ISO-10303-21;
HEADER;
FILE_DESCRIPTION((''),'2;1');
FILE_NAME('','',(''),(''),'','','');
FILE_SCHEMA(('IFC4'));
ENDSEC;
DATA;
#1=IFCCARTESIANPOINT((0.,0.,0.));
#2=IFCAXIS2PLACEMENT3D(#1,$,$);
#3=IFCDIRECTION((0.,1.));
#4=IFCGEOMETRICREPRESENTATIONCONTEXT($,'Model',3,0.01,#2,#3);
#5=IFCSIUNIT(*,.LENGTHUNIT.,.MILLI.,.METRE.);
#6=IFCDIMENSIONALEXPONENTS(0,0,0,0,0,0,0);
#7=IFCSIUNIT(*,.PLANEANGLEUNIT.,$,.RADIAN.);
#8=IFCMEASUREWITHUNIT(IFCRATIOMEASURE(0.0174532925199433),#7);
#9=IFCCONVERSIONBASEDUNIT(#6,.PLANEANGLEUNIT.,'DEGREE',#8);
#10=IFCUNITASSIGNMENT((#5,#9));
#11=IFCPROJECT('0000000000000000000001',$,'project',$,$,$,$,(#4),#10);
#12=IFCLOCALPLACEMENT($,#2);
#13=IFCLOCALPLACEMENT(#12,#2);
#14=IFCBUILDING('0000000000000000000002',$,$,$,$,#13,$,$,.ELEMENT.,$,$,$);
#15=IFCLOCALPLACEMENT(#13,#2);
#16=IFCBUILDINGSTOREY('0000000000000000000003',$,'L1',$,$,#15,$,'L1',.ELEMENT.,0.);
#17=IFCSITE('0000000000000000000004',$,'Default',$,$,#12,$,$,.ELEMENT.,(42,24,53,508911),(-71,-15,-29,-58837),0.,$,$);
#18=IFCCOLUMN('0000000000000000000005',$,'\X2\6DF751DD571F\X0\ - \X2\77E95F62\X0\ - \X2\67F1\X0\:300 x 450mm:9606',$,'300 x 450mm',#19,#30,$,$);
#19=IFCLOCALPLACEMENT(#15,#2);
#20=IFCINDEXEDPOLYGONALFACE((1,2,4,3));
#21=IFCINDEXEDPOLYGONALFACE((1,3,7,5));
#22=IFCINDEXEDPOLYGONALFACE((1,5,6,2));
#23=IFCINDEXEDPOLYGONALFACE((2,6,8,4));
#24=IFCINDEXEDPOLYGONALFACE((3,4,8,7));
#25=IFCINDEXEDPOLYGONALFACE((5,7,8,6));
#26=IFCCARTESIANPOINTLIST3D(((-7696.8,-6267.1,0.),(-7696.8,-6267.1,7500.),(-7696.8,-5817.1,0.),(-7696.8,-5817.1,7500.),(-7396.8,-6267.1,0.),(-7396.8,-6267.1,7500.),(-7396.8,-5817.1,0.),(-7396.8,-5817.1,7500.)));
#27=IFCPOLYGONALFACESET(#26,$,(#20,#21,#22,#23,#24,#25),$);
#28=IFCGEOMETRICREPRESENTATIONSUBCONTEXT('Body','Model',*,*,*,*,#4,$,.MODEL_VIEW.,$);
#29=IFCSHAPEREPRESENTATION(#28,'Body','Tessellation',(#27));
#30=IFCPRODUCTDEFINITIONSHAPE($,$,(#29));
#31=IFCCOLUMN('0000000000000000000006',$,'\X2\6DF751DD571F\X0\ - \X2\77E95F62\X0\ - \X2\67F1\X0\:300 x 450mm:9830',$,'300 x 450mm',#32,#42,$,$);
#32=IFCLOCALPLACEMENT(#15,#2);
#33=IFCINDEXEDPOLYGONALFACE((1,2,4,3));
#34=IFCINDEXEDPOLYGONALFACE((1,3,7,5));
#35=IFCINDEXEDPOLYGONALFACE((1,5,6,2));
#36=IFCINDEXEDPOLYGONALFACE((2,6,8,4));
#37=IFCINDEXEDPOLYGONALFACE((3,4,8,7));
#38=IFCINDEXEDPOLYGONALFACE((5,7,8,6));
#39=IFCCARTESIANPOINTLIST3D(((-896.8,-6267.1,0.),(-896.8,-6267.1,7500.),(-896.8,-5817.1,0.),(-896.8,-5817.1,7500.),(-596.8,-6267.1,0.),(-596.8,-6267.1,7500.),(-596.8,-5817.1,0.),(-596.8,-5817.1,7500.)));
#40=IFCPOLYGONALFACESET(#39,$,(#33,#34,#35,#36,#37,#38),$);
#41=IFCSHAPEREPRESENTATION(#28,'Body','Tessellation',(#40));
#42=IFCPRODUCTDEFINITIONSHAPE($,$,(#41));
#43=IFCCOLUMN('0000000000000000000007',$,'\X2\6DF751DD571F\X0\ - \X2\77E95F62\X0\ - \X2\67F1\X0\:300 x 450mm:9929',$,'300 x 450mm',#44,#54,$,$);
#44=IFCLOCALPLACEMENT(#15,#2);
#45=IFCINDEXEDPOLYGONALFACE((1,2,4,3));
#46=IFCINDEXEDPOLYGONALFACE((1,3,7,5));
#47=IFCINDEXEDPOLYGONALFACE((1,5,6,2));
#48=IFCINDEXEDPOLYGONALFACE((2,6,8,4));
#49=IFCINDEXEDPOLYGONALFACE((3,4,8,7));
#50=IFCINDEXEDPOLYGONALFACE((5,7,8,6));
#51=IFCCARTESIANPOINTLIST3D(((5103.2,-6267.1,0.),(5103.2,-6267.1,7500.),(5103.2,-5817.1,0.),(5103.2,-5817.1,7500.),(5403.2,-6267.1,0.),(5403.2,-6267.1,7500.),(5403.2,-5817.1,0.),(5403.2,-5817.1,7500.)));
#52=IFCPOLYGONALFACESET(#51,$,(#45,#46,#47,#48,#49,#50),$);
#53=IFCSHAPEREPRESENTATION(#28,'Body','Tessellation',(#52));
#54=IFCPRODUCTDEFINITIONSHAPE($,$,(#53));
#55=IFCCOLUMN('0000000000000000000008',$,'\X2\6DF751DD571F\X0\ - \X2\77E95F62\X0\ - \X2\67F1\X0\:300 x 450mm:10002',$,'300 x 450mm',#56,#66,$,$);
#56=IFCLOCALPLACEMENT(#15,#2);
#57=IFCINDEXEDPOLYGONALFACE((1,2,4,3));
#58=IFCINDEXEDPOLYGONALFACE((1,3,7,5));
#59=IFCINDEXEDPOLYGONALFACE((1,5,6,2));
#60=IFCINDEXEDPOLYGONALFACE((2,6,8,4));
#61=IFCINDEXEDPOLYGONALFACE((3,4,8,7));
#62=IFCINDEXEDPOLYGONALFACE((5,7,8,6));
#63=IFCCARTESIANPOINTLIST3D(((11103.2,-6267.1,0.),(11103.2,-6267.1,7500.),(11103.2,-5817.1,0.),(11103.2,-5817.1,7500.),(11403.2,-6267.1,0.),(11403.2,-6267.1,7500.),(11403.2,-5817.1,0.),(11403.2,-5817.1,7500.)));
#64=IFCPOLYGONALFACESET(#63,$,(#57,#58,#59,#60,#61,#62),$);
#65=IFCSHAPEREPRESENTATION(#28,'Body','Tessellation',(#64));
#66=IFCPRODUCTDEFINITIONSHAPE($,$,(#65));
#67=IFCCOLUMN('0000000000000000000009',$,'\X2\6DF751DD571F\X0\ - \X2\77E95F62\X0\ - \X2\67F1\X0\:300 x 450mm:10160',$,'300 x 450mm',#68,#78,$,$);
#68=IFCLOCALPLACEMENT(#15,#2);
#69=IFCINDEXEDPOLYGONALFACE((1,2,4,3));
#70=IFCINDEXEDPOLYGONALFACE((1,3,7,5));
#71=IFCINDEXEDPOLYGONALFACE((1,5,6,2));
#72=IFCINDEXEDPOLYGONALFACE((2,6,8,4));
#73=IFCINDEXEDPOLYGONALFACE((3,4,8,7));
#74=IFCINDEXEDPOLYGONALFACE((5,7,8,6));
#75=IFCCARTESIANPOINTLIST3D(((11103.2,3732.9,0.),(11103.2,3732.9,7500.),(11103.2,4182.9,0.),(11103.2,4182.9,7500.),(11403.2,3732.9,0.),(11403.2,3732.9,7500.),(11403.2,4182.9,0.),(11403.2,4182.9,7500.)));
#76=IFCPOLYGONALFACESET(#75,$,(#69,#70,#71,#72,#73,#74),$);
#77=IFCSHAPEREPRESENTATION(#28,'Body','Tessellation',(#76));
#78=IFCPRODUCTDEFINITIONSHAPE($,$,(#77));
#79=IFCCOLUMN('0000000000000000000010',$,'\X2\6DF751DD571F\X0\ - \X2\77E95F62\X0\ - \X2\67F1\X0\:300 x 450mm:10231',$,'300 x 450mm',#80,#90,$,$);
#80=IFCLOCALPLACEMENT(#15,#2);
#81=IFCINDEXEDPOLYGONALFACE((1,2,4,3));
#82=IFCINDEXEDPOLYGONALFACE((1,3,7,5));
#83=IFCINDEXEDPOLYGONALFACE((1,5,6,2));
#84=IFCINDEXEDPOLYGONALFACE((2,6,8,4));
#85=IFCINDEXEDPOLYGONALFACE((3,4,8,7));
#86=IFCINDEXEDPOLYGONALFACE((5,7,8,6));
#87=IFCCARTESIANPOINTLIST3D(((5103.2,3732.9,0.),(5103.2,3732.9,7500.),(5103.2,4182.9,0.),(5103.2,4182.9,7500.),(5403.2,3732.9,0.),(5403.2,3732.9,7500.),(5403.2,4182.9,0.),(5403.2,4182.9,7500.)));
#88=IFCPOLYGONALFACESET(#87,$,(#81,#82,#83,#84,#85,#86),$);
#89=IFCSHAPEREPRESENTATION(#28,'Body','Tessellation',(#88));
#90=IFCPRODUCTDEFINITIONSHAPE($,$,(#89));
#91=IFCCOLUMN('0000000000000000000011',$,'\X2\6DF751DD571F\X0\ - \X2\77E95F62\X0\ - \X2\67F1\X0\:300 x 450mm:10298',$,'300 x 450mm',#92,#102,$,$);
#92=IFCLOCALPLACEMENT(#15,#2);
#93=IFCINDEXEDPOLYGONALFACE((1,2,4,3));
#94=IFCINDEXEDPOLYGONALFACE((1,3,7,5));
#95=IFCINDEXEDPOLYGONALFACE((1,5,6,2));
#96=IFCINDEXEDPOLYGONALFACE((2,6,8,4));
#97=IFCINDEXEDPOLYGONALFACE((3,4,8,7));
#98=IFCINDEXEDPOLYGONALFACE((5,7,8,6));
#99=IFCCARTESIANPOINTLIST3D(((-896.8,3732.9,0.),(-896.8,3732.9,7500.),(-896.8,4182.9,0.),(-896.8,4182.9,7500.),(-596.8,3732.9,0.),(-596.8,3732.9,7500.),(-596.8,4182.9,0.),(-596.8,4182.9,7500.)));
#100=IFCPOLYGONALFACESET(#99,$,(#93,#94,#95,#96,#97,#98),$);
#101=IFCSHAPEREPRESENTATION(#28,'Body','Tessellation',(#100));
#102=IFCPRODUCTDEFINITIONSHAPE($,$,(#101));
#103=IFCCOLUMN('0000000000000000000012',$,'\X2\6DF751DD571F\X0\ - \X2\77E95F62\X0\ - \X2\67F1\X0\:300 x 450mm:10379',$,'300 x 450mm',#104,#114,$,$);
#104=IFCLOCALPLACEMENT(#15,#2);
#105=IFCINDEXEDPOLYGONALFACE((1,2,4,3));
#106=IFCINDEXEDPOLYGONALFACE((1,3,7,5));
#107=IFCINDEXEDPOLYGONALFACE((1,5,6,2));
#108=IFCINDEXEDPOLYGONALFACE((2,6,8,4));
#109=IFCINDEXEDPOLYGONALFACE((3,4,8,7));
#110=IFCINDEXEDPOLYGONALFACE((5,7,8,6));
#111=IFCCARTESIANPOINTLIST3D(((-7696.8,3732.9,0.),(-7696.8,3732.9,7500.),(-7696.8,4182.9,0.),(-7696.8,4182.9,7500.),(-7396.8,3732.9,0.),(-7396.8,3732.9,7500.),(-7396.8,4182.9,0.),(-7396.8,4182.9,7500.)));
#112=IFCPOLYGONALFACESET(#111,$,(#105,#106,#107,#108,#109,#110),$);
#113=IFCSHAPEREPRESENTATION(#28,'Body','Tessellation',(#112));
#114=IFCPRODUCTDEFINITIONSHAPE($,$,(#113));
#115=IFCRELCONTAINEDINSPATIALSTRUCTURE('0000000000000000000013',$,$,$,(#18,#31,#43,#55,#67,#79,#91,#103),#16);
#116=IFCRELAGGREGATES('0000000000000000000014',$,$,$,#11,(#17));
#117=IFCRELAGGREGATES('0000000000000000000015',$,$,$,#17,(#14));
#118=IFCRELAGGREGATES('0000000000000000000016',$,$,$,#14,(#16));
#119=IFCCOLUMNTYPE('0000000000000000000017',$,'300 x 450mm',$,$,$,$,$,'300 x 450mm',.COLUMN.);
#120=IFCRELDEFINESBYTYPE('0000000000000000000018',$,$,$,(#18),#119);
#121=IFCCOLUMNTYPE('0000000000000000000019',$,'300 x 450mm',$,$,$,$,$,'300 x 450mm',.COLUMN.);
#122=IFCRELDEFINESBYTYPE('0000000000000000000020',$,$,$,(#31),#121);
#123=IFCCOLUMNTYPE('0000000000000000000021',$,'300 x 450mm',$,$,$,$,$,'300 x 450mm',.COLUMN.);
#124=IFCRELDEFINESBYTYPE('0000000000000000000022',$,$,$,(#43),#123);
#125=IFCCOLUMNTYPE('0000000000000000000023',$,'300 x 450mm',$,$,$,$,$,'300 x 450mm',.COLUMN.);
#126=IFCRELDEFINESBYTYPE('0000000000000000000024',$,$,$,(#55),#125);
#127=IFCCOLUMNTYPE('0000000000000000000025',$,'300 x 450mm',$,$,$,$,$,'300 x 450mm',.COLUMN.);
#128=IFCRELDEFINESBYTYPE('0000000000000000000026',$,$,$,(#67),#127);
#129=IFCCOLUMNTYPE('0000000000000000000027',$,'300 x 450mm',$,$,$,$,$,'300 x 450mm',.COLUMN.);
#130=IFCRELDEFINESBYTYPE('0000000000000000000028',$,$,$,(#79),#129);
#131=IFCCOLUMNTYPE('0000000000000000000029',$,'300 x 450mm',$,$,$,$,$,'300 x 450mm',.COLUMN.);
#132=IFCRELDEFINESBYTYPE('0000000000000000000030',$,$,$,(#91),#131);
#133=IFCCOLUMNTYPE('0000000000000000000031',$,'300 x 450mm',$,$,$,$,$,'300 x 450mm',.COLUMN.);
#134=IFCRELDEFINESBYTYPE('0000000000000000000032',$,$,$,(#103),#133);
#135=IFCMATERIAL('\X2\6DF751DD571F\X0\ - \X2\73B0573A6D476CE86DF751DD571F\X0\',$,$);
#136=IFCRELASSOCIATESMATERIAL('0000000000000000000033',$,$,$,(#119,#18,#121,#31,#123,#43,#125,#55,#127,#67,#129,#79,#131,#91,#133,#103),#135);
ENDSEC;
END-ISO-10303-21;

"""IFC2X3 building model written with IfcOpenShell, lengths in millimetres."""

from ifc_helpers import new_model, entity, si_unit, converted_unit, direction, frame, frame_2d, origin, origin_2d_with_axis, place, context, subcontext, project, spatial, rectangle, extrude, source, transform, mapped, material, type_object, type_shapes, element, save


model = new_model("IFC2X3")

# Units and contexts
model_context = context("Model", 3, precision=0.01, world=origin(), true_north=direction((0.0, 1.0)))
body_context = subcontext(model_context, "Body", "Model", "MODEL_VIEW")
ifc_project = project(units=[si_unit("LENGTHUNIT", "METRE", prefix="MILLI"), converted_unit("PLANEANGLEUNIT", "DEGREE", entity("IfcRatioMeasure", 0.0174532925199433), si_unit("PLANEANGLEUNIT", "RADIAN"), dimensions=[0, 0, 0, 0, 0, 0, 0])], contexts=[model_context])

# Site, building, storey
site_placement = place(None, origin())
site = spatial("IfcSite", under=ifc_project, at=site_placement, Name="Default", CompositionType="ELEMENT", RefLatitude=(42, 24, 53, 508911), RefLongitude=(-71, -15, -29, -58837), RefElevation=0.0)
building_placement = place(site_placement, origin())
building = spatial("IfcBuilding", under=site, at=building_placement, CompositionType="ELEMENT")
storey_placement = place(building_placement, origin())
storey = spatial("IfcBuildingStorey", under=building, at=storey_placement, Name="L1", LongName="L1", CompositionType="ELEMENT", Elevation=0.0)

# Columns
ifc_material = material(Name="混凝土 - 现场浇注混凝土")
column_type_1 = type_object("IfcColumnType", Name="300 x 450mm", ElementType="300 x 450mm", PredefinedType="COLUMN", material=ifc_material)
shared_shape_1 = source(origin(), body_context, "Body", "SweptSolid", [
    extrude(rectangle(XDim=450.0, YDim=300.0, at=frame_2d((0.0, 0.0), x_axis=(1.0, 0.0))), frame((-7546.8, -6042.1, 0.0), z_axis=(0.0, 0.0, 1.0), x_axis=(0.0, -1.0, 0.0)), (0.0, 0.0, 1.0), 7500.0),
])
type_shapes(column_type_1, [shared_shape_1])
column_1_placement = place(storey_placement, origin())
element("IfcColumn", 1, at=column_1_placement, inside=storey, type_object=column_type_1, material=ifc_material, Name="混凝土 - 矩形 - 柱:300 x 450mm:9606", ObjectType="300 x 450mm", context=body_context, shape_type="MappedRepresentation", body=[
    mapped(shared_shape_1, transform((0.0, 0.0, 0.0), scale=1.0)),
])
column_type_2 = type_object("IfcColumnType", Name="300 x 450mm", ElementType="300 x 450mm", PredefinedType="COLUMN", material=ifc_material)
shared_shape_2 = source(origin(), body_context, "Body", "SweptSolid", [
    extrude(rectangle(XDim=450.0, YDim=300.0, at=origin_2d_with_axis()), frame((-746.8, -6042.1, 0.0), z_axis=(0.0, 0.0, 1.0), x_axis=(0.0, -1.0, 0.0)), (0.0, 0.0, 1.0), 7500.0),
])
type_shapes(column_type_2, [shared_shape_2])
column_2_placement = place(storey_placement, origin())
element("IfcColumn", 2, at=column_2_placement, inside=storey, type_object=column_type_2, material=ifc_material, Name="混凝土 - 矩形 - 柱:300 x 450mm:9830", ObjectType="300 x 450mm", context=body_context, shape_type="MappedRepresentation", body=[
    mapped(shared_shape_2, transform((0.0, 0.0, 0.0), scale=1.0)),
])
column_type_3 = type_object("IfcColumnType", Name="300 x 450mm", ElementType="300 x 450mm", PredefinedType="COLUMN", material=ifc_material)
shared_shape_3 = source(origin(), body_context, "Body", "SweptSolid", [
    extrude(rectangle(XDim=450.0, YDim=300.0, at=frame_2d((0.0, 0.0), x_axis=(1.0, 0.0))), frame((5253.2, -6042.1, 0.0), z_axis=(0.0, 0.0, 1.0), x_axis=(0.0, -1.0, 0.0)), (0.0, 0.0, 1.0), 7500.0),
])
type_shapes(column_type_3, [shared_shape_3])
column_3_placement = place(storey_placement, origin())
element("IfcColumn", 3, at=column_3_placement, inside=storey, type_object=column_type_3, material=ifc_material, Name="混凝土 - 矩形 - 柱:300 x 450mm:9929", ObjectType="300 x 450mm", context=body_context, shape_type="MappedRepresentation", body=[
    mapped(shared_shape_3, transform((0.0, 0.0, 0.0), scale=1.0)),
])
column_type_4 = type_object("IfcColumnType", Name="300 x 450mm", ElementType="300 x 450mm", PredefinedType="COLUMN", material=ifc_material)
shared_shape_4 = source(origin(), body_context, "Body", "SweptSolid", [
    extrude(rectangle(XDim=450.0, YDim=300.0, at=origin_2d_with_axis()), frame((11253.2, -6042.1, 0.0), z_axis=(0.0, 0.0, 1.0), x_axis=(0.0, -1.0, 0.0)), (0.0, 0.0, 1.0), 7500.0),
])
type_shapes(column_type_4, [shared_shape_4])
column_4_placement = place(storey_placement, origin())
element("IfcColumn", 4, at=column_4_placement, inside=storey, type_object=column_type_4, material=ifc_material, Name="混凝土 - 矩形 - 柱:300 x 450mm:10002", ObjectType="300 x 450mm", context=body_context, shape_type="MappedRepresentation", body=[
    mapped(shared_shape_4, transform((0.0, 0.0, 0.0), scale=1.0)),
])
column_type_5 = type_object("IfcColumnType", Name="300 x 450mm", ElementType="300 x 450mm", PredefinedType="COLUMN", material=ifc_material)
shared_shape_5 = source(origin(), body_context, "Body", "SweptSolid", [
    extrude(rectangle(XDim=450.0, YDim=300.0, at=frame_2d((0.0, 0.0), x_axis=(1.0, 0.0))), frame((11253.2, 3957.9, 0.0), z_axis=(0.0, 0.0, 1.0), x_axis=(0.0, -1.0, 0.0)), (0.0, 0.0, 1.0), 7500.0),
])
type_shapes(column_type_5, [shared_shape_5])
column_5_placement = place(storey_placement, origin())
element("IfcColumn", 5, at=column_5_placement, inside=storey, type_object=column_type_5, material=ifc_material, Name="混凝土 - 矩形 - 柱:300 x 450mm:10160", ObjectType="300 x 450mm", context=body_context, shape_type="MappedRepresentation", body=[
    mapped(shared_shape_5, transform((0.0, 0.0, 0.0), scale=1.0)),
])
column_type_6 = type_object("IfcColumnType", Name="300 x 450mm", ElementType="300 x 450mm", PredefinedType="COLUMN", material=ifc_material)
shared_shape_6 = source(origin(), body_context, "Body", "SweptSolid", [
    extrude(rectangle(XDim=450.0, YDim=300.0, at=frame_2d((0.0, 0.0), x_axis=(1.0, 0.0))), frame((5253.2, 3957.9, 0.0), z_axis=(0.0, 0.0, 1.0), x_axis=(0.0, -1.0, 0.0)), (0.0, 0.0, 1.0), 7500.0),
])
type_shapes(column_type_6, [shared_shape_6])
column_6_placement = place(storey_placement, origin())
element("IfcColumn", 6, at=column_6_placement, inside=storey, type_object=column_type_6, material=ifc_material, Name="混凝土 - 矩形 - 柱:300 x 450mm:10231", ObjectType="300 x 450mm", context=body_context, shape_type="MappedRepresentation", body=[
    mapped(shared_shape_6, transform((0.0, 0.0, 0.0), scale=1.0)),
])
column_type_7 = type_object("IfcColumnType", Name="300 x 450mm", ElementType="300 x 450mm", PredefinedType="COLUMN", material=ifc_material)
shared_shape_7 = source(origin(), body_context, "Body", "SweptSolid", [
    extrude(rectangle(XDim=450.0, YDim=300.0, at=frame_2d((0.0, 0.0), x_axis=(1.0, 0.0))), frame((-746.8, 3957.9, 0.0), z_axis=(0.0, 0.0, 1.0), x_axis=(0.0, -1.0, 0.0)), (0.0, 0.0, 1.0), 7500.0),
])
type_shapes(column_type_7, [shared_shape_7])
column_7_placement = place(storey_placement, origin())
element("IfcColumn", 7, at=column_7_placement, inside=storey, type_object=column_type_7, material=ifc_material, Name="混凝土 - 矩形 - 柱:300 x 450mm:10298", ObjectType="300 x 450mm", context=body_context, shape_type="MappedRepresentation", body=[
    mapped(shared_shape_7, transform((0.0, 0.0, 0.0), scale=1.0)),
])
column_type_8 = type_object("IfcColumnType", Name="300 x 450mm", ElementType="300 x 450mm", PredefinedType="COLUMN", material=ifc_material)
shared_shape_8 = source(origin(), body_context, "Body", "SweptSolid", [
    extrude(rectangle(XDim=450.0, YDim=300.0, at=frame_2d((0.0, 0.0), x_axis=(1.0, 0.0))), frame((-7546.8, 3957.9, 0.0), z_axis=(0.0, 0.0, 1.0), x_axis=(0.0, -1.0, 0.0)), (0.0, 0.0, 1.0), 7500.0),
])
type_shapes(column_type_8, [shared_shape_8])
column_8_placement = place(storey_placement, origin())
element("IfcColumn", 8, at=column_8_placement, inside=storey, type_object=column_type_8, material=ifc_material, Name="混凝土 - 矩形 - 柱:300 x 450mm:10379", ObjectType="300 x 450mm", context=body_context, shape_type="MappedRepresentation", body=[
    mapped(shared_shape_8, transform((0.0, 0.0, 0.0), scale=1.0)),
])

save(model, "model.ifc")
